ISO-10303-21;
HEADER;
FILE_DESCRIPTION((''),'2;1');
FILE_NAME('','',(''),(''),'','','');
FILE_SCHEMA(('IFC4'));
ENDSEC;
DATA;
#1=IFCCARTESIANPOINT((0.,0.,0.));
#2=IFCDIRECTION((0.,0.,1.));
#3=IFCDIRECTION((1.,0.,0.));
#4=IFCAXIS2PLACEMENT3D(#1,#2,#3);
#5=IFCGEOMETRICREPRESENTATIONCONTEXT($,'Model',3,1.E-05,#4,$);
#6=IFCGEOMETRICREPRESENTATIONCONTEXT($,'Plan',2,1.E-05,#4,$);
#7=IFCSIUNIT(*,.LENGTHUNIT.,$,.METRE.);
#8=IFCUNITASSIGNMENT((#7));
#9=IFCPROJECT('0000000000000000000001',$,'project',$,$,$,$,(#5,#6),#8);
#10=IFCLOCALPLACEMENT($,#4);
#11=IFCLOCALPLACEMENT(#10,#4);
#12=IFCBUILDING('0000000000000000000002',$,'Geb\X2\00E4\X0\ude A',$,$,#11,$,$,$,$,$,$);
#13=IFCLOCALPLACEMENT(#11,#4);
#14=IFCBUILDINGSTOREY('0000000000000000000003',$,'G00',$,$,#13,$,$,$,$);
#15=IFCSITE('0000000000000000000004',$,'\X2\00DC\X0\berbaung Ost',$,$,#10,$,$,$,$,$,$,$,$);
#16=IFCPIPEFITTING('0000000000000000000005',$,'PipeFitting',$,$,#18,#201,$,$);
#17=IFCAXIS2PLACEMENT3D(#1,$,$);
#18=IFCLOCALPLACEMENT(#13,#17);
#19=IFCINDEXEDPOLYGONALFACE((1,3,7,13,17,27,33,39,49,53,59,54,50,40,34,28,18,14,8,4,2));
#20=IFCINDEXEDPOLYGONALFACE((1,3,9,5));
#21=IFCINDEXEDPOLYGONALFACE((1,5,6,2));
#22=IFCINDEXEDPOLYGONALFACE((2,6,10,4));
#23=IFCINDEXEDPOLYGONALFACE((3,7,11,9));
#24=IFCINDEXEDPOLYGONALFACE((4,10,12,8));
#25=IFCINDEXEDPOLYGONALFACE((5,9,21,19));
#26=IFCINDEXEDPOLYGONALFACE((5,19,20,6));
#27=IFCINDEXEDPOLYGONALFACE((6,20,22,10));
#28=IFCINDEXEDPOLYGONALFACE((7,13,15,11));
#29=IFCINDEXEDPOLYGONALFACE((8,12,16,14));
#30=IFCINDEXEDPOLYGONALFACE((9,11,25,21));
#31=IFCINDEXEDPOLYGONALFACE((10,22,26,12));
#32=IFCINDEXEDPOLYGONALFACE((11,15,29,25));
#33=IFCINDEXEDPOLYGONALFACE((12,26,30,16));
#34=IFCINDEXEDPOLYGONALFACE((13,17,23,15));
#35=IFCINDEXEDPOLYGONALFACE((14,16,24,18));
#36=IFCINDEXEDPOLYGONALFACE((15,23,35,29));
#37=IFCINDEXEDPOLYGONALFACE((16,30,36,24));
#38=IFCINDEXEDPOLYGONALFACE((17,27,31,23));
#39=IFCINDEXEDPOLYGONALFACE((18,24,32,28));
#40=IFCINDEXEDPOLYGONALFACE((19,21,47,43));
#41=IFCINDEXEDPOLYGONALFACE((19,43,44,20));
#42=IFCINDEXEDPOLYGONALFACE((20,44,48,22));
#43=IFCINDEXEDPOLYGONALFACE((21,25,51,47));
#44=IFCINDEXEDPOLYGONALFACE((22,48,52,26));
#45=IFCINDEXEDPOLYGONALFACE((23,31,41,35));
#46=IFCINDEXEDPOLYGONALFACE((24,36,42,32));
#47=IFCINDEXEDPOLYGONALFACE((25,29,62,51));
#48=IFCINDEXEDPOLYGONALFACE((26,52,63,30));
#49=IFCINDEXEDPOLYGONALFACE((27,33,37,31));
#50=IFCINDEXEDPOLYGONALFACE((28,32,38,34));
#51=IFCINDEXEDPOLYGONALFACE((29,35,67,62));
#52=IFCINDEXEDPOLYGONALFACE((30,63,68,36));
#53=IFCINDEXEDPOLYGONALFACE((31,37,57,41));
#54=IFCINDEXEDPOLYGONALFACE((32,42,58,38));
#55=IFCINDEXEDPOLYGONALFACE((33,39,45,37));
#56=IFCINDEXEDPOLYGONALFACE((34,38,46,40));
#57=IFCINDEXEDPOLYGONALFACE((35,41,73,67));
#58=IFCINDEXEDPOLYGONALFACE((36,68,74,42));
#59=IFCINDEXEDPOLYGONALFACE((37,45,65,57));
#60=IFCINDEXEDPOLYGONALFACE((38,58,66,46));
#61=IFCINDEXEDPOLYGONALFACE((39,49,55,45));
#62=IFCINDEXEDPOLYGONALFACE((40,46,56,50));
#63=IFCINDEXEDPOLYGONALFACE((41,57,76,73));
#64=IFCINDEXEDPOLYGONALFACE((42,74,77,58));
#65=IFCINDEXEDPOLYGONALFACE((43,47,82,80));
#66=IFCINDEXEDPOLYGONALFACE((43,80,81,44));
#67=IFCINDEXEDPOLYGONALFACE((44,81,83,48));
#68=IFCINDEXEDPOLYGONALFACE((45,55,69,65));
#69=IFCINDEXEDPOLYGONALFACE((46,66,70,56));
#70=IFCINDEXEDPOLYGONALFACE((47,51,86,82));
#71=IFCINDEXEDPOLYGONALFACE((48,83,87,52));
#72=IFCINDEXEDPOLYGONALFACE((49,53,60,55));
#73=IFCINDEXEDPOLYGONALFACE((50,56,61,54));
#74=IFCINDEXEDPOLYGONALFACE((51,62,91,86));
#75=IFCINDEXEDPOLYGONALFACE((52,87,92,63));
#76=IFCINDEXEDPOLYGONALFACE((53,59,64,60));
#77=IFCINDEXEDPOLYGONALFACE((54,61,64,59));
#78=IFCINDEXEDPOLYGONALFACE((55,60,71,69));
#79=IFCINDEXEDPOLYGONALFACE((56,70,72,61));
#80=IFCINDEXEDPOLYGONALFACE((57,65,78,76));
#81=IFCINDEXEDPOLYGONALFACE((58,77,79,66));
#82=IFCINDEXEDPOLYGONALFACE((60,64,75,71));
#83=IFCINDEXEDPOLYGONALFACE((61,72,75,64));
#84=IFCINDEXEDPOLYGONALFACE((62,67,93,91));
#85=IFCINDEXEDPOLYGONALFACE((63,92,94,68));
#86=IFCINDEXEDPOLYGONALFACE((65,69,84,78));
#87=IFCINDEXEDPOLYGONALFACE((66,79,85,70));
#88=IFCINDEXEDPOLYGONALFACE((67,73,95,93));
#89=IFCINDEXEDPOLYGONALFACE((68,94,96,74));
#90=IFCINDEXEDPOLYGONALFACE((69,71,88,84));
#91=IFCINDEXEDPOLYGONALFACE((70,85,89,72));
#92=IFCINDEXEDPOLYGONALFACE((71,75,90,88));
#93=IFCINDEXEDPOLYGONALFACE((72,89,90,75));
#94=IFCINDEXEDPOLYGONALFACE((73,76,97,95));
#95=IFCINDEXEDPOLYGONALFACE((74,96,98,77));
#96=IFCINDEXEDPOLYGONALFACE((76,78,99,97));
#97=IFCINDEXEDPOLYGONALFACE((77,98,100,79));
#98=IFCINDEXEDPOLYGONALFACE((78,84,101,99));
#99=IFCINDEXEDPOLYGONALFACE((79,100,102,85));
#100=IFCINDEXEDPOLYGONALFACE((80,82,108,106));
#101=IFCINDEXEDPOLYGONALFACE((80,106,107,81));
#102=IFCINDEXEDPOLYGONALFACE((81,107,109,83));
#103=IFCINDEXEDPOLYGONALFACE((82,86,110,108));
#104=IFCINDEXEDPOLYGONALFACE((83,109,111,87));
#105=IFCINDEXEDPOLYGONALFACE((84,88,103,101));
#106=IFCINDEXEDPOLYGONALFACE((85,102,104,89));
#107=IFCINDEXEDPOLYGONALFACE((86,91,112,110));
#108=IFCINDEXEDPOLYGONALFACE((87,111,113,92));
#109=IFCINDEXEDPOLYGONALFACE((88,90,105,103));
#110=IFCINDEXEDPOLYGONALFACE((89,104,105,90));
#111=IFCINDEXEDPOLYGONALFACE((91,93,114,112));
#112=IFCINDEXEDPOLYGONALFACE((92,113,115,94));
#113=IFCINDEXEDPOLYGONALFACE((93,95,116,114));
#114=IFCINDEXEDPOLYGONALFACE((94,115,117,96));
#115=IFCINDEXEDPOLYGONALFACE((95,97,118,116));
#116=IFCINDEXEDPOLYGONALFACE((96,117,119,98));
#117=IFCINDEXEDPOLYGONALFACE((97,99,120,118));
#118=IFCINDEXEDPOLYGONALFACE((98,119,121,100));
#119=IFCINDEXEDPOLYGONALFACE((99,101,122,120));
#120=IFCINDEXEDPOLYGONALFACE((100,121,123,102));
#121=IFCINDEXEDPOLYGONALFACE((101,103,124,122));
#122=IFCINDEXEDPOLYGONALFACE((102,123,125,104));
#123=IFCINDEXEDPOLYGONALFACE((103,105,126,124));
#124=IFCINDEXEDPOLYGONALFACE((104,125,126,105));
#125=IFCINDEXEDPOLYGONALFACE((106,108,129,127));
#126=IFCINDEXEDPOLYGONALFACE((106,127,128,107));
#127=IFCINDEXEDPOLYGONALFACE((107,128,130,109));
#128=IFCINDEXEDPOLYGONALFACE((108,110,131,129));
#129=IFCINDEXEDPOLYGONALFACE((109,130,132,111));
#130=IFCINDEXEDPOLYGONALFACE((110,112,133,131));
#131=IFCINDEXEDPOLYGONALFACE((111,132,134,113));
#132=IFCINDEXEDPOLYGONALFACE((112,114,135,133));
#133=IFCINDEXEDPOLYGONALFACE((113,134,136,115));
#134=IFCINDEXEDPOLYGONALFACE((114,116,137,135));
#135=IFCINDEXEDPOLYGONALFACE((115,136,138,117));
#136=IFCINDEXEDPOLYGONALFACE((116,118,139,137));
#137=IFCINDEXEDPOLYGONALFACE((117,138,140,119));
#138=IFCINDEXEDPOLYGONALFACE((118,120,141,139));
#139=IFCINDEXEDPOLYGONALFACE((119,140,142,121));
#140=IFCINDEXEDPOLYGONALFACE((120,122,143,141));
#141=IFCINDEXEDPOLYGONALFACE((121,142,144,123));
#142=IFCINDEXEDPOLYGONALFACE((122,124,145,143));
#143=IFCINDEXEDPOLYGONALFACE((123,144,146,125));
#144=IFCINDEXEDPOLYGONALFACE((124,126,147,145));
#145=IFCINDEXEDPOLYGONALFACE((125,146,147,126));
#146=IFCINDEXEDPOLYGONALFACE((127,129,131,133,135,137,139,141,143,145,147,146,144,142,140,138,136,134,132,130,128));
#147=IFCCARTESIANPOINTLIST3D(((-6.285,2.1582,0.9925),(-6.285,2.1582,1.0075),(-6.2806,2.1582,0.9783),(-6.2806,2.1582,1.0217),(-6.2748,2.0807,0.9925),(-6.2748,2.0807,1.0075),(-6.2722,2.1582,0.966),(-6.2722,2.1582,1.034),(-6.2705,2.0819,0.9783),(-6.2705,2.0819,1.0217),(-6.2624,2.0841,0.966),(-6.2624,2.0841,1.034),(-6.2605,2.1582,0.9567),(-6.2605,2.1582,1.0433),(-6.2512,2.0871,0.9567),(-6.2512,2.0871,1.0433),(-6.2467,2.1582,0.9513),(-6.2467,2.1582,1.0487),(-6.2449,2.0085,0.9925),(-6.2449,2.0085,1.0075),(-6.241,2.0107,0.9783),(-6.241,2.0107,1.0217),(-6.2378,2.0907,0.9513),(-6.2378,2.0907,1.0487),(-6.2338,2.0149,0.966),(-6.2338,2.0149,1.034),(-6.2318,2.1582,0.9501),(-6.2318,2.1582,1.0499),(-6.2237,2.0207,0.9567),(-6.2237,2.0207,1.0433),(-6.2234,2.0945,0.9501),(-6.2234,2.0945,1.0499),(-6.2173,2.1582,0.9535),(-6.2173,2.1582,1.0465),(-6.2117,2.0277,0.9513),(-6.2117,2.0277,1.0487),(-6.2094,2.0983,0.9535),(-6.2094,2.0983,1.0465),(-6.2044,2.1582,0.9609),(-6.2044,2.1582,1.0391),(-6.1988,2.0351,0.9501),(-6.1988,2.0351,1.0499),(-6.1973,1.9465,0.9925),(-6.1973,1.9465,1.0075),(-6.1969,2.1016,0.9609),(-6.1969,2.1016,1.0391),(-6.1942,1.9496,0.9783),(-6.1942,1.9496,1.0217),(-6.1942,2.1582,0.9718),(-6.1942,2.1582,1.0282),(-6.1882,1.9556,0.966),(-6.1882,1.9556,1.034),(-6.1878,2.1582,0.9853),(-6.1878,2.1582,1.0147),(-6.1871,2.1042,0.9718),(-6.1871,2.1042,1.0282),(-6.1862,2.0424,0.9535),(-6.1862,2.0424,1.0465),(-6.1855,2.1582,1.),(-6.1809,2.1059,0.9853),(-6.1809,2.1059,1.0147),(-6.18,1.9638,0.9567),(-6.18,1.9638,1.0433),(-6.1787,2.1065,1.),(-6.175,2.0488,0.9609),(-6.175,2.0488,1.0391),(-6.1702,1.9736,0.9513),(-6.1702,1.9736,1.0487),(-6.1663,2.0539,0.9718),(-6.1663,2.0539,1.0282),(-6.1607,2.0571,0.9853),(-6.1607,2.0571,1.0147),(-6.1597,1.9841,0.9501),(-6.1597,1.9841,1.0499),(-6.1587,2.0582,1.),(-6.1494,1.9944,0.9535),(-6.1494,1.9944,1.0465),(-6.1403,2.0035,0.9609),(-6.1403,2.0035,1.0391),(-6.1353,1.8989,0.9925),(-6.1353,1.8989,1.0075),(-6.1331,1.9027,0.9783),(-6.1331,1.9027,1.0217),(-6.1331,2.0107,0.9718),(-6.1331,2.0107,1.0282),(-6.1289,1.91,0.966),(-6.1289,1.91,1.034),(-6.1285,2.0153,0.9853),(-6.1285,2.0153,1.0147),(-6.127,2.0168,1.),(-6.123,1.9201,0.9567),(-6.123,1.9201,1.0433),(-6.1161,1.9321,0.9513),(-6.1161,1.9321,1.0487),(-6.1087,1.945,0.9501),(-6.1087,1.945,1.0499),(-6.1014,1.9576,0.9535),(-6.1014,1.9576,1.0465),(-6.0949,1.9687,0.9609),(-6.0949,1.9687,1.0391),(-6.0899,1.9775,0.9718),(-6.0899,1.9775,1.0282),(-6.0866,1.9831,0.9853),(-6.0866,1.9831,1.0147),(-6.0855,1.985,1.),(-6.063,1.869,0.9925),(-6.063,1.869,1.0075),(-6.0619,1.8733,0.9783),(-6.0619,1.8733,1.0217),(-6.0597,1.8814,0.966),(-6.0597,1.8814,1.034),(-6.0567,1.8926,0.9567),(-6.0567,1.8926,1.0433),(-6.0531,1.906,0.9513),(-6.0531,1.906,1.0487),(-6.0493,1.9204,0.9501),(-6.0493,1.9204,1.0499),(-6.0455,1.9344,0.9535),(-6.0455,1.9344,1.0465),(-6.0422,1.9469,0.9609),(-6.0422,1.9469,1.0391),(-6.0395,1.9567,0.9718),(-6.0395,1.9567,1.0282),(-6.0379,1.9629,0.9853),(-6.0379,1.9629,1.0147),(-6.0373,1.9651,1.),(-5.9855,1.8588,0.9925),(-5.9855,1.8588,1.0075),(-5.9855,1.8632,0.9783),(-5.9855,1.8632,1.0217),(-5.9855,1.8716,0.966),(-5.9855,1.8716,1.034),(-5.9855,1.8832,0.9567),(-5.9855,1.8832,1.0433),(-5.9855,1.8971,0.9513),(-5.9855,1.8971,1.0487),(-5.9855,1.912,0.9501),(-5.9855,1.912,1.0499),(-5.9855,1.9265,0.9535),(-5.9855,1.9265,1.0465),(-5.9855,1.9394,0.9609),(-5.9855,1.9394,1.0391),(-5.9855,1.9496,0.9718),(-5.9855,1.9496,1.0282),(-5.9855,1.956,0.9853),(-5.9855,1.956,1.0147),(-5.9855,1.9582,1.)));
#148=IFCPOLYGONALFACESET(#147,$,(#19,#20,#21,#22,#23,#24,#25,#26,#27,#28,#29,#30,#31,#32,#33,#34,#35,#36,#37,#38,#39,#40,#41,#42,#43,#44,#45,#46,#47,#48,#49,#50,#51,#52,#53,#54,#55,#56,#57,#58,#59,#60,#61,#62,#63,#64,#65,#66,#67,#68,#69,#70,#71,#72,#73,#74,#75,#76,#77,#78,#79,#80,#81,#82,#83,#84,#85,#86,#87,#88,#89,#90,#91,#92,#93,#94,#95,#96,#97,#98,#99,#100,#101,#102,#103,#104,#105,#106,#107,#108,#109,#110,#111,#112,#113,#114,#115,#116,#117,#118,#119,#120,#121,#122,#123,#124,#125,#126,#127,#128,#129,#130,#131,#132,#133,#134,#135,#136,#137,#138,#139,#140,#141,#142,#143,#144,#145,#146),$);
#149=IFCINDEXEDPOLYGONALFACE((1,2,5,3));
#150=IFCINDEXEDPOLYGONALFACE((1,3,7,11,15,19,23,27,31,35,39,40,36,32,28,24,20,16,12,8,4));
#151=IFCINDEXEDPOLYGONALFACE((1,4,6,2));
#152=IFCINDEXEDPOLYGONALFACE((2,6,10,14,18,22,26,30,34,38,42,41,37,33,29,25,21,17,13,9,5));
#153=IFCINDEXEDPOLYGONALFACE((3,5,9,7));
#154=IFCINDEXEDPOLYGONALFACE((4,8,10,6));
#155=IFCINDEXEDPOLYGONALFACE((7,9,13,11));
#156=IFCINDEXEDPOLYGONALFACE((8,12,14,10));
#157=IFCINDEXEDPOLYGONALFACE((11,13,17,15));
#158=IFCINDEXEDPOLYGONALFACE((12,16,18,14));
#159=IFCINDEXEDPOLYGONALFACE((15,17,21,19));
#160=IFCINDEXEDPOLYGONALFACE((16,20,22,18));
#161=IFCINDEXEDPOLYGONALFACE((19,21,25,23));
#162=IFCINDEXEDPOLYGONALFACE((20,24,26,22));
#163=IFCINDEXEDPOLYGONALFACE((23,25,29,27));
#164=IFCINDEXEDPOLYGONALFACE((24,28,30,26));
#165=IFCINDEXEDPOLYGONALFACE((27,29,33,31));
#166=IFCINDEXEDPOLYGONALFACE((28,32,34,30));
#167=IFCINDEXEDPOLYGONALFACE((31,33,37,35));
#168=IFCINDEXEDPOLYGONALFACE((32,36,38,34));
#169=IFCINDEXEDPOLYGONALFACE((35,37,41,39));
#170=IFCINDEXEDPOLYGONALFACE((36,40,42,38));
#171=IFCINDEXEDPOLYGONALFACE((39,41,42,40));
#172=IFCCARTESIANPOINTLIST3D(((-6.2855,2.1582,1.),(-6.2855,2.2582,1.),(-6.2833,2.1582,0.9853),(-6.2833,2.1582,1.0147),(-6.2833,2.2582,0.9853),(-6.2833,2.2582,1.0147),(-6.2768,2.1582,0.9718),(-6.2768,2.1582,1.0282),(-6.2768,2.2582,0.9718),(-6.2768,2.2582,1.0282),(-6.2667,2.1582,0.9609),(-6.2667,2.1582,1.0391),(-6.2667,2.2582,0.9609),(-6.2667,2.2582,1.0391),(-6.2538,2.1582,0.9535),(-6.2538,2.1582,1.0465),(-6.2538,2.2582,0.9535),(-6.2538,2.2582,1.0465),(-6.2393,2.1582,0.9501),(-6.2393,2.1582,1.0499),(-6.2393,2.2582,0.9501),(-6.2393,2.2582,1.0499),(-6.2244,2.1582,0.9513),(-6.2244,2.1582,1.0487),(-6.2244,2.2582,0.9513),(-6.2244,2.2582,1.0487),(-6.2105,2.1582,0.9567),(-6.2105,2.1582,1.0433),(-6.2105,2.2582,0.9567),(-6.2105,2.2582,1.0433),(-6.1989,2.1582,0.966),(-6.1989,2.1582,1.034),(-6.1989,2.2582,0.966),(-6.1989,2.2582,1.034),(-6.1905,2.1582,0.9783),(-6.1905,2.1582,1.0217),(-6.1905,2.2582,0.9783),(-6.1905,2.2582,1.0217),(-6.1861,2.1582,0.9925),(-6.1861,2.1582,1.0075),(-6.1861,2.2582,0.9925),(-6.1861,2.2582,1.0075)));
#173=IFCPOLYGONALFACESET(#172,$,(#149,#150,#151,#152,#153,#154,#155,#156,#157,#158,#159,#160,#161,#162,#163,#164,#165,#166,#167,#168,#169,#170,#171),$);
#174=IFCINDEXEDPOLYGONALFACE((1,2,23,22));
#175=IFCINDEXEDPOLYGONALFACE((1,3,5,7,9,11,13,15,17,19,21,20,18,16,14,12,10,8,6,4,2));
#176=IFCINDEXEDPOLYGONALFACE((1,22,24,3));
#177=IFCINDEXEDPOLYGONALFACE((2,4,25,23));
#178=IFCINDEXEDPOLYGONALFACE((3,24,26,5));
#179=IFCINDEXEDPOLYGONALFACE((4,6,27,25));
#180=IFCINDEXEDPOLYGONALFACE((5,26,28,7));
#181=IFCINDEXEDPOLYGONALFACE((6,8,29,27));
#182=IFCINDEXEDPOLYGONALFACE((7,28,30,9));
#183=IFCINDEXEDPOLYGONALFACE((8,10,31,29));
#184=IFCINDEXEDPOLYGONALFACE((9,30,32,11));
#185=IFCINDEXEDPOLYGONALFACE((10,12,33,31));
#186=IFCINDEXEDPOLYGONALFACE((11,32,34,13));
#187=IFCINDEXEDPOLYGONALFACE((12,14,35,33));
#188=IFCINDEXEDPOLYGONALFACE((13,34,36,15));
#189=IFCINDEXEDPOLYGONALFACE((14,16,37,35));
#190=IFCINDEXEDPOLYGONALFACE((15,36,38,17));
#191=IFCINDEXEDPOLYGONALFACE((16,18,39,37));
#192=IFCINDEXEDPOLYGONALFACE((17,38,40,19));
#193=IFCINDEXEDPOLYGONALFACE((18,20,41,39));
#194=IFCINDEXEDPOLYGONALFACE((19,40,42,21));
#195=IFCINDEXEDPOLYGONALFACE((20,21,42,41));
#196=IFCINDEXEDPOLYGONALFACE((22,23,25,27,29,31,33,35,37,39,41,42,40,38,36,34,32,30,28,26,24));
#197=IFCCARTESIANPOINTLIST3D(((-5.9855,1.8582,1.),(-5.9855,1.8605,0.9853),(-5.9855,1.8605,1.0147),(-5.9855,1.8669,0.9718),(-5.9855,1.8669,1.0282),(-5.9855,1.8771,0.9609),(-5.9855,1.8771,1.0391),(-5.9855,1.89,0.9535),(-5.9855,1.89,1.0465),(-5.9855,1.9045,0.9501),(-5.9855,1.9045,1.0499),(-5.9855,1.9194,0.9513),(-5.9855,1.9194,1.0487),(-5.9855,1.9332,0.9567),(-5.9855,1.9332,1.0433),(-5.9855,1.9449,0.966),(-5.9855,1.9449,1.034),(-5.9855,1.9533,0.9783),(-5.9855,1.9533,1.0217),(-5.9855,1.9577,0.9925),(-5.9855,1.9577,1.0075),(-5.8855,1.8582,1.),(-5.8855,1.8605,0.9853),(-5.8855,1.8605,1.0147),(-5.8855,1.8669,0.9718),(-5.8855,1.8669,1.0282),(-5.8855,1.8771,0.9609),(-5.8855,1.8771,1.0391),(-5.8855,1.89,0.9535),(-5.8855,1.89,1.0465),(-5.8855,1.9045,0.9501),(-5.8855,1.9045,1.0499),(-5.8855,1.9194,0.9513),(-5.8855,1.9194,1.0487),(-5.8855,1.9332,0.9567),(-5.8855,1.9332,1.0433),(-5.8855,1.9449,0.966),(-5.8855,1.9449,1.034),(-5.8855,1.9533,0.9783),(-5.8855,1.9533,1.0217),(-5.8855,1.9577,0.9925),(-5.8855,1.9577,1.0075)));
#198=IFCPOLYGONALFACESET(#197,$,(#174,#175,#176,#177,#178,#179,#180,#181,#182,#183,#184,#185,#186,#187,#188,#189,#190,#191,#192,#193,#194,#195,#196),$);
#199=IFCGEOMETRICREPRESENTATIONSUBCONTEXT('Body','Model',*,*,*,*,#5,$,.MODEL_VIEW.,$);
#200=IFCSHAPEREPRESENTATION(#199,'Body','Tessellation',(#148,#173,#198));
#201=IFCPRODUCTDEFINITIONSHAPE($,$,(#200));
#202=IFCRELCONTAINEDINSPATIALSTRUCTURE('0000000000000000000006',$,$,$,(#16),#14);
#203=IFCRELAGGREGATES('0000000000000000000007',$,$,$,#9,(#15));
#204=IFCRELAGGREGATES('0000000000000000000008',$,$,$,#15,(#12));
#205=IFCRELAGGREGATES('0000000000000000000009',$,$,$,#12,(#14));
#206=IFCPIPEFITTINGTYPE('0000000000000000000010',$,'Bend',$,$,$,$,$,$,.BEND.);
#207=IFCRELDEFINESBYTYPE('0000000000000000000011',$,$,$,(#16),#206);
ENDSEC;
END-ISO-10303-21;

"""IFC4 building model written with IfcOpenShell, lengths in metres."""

from ifc_helpers import new_model, entity, si_unit, frame, origin_with_axes, place, context, subcontext, project, spatial, circle, extrude, source, transform, mapped, type_object, type_shapes, element, save


model = new_model("IFC4")

# Units and contexts
model_context = context("Model", 3, precision=1e-05, world=origin_with_axes())
plan_context = context("Plan", 2, precision=1e-05, world=origin_with_axes())
body_context = subcontext(model_context, "Body", "Model", "MODEL_VIEW")
ifc_project = project(units=[si_unit("LENGTHUNIT", "METRE")], contexts=[model_context, plan_context])

# Site, building, storey
site_placement = place(None, origin_with_axes())
site = spatial("IfcSite", under=ifc_project, at=site_placement, Name="Überbaung Ost")
building_placement = place(site_placement, origin_with_axes())
building = spatial("IfcBuilding", under=site, at=building_placement, Name="Gebäude A")
storey_placement = place(building_placement, origin_with_axes())
storey = spatial("IfcBuildingStorey", under=building, at=storey_placement, Name="G00")

# Pipe fitting
pipe_fitting_type = type_object("IfcPipeFittingType", Name="Bend", PredefinedType="BEND")
shared_shape = source(origin_with_axes(), body_context, "Body", "AdvancedSweptSolid", [
    entity("IfcSweptDiskSolid", entity("IfcIndexedPolyCurve", entity("IfcCartesianPointList3D", [[0.0, 0.0, -0.1], [-0.0732, 0.0, -0.2768], [-0.25, 0.0, -0.35]]), [entity("IfcArcIndex", [1, 2, 3])]), 0.05),
    extrude(circle(Radius=0.05), origin_with_axes(), (0.0, 0.0, -1.0), 0.1),
    extrude(circle(Radius=0.05), frame((-0.25, 0.0, -0.35), z_axis=(-1.0, 0.0, 0.0), x_axis=(0.0, 0.0, -1.0)), (0.0, 0.0, 1.0), 0.1),
])
type_shapes(pipe_fitting_type, [shared_shape])
pipe_fitting_placement = place(storey_placement, frame((-6.2355, 2.2582, 1.0), z_axis=(0.0, 1.0, 0.0), x_axis=(-1.0, 0.0, 0.0)))
element("IfcPipeFitting", 1, at=pipe_fitting_placement, inside=storey, type_object=pipe_fitting_type, Name="PipeFitting", context=body_context, shape_type="MappedRepresentation", body=[
    mapped(shared_shape, transform((0.0, 0.0, 0.0), x_axis=(1.0, 0.0, 0.0), y_axis=(0.0, 1.0, 0.0), z_axis=(0.0, 0.0, 1.0), scale=1.0)),
])

save(model, "model.ifc")
